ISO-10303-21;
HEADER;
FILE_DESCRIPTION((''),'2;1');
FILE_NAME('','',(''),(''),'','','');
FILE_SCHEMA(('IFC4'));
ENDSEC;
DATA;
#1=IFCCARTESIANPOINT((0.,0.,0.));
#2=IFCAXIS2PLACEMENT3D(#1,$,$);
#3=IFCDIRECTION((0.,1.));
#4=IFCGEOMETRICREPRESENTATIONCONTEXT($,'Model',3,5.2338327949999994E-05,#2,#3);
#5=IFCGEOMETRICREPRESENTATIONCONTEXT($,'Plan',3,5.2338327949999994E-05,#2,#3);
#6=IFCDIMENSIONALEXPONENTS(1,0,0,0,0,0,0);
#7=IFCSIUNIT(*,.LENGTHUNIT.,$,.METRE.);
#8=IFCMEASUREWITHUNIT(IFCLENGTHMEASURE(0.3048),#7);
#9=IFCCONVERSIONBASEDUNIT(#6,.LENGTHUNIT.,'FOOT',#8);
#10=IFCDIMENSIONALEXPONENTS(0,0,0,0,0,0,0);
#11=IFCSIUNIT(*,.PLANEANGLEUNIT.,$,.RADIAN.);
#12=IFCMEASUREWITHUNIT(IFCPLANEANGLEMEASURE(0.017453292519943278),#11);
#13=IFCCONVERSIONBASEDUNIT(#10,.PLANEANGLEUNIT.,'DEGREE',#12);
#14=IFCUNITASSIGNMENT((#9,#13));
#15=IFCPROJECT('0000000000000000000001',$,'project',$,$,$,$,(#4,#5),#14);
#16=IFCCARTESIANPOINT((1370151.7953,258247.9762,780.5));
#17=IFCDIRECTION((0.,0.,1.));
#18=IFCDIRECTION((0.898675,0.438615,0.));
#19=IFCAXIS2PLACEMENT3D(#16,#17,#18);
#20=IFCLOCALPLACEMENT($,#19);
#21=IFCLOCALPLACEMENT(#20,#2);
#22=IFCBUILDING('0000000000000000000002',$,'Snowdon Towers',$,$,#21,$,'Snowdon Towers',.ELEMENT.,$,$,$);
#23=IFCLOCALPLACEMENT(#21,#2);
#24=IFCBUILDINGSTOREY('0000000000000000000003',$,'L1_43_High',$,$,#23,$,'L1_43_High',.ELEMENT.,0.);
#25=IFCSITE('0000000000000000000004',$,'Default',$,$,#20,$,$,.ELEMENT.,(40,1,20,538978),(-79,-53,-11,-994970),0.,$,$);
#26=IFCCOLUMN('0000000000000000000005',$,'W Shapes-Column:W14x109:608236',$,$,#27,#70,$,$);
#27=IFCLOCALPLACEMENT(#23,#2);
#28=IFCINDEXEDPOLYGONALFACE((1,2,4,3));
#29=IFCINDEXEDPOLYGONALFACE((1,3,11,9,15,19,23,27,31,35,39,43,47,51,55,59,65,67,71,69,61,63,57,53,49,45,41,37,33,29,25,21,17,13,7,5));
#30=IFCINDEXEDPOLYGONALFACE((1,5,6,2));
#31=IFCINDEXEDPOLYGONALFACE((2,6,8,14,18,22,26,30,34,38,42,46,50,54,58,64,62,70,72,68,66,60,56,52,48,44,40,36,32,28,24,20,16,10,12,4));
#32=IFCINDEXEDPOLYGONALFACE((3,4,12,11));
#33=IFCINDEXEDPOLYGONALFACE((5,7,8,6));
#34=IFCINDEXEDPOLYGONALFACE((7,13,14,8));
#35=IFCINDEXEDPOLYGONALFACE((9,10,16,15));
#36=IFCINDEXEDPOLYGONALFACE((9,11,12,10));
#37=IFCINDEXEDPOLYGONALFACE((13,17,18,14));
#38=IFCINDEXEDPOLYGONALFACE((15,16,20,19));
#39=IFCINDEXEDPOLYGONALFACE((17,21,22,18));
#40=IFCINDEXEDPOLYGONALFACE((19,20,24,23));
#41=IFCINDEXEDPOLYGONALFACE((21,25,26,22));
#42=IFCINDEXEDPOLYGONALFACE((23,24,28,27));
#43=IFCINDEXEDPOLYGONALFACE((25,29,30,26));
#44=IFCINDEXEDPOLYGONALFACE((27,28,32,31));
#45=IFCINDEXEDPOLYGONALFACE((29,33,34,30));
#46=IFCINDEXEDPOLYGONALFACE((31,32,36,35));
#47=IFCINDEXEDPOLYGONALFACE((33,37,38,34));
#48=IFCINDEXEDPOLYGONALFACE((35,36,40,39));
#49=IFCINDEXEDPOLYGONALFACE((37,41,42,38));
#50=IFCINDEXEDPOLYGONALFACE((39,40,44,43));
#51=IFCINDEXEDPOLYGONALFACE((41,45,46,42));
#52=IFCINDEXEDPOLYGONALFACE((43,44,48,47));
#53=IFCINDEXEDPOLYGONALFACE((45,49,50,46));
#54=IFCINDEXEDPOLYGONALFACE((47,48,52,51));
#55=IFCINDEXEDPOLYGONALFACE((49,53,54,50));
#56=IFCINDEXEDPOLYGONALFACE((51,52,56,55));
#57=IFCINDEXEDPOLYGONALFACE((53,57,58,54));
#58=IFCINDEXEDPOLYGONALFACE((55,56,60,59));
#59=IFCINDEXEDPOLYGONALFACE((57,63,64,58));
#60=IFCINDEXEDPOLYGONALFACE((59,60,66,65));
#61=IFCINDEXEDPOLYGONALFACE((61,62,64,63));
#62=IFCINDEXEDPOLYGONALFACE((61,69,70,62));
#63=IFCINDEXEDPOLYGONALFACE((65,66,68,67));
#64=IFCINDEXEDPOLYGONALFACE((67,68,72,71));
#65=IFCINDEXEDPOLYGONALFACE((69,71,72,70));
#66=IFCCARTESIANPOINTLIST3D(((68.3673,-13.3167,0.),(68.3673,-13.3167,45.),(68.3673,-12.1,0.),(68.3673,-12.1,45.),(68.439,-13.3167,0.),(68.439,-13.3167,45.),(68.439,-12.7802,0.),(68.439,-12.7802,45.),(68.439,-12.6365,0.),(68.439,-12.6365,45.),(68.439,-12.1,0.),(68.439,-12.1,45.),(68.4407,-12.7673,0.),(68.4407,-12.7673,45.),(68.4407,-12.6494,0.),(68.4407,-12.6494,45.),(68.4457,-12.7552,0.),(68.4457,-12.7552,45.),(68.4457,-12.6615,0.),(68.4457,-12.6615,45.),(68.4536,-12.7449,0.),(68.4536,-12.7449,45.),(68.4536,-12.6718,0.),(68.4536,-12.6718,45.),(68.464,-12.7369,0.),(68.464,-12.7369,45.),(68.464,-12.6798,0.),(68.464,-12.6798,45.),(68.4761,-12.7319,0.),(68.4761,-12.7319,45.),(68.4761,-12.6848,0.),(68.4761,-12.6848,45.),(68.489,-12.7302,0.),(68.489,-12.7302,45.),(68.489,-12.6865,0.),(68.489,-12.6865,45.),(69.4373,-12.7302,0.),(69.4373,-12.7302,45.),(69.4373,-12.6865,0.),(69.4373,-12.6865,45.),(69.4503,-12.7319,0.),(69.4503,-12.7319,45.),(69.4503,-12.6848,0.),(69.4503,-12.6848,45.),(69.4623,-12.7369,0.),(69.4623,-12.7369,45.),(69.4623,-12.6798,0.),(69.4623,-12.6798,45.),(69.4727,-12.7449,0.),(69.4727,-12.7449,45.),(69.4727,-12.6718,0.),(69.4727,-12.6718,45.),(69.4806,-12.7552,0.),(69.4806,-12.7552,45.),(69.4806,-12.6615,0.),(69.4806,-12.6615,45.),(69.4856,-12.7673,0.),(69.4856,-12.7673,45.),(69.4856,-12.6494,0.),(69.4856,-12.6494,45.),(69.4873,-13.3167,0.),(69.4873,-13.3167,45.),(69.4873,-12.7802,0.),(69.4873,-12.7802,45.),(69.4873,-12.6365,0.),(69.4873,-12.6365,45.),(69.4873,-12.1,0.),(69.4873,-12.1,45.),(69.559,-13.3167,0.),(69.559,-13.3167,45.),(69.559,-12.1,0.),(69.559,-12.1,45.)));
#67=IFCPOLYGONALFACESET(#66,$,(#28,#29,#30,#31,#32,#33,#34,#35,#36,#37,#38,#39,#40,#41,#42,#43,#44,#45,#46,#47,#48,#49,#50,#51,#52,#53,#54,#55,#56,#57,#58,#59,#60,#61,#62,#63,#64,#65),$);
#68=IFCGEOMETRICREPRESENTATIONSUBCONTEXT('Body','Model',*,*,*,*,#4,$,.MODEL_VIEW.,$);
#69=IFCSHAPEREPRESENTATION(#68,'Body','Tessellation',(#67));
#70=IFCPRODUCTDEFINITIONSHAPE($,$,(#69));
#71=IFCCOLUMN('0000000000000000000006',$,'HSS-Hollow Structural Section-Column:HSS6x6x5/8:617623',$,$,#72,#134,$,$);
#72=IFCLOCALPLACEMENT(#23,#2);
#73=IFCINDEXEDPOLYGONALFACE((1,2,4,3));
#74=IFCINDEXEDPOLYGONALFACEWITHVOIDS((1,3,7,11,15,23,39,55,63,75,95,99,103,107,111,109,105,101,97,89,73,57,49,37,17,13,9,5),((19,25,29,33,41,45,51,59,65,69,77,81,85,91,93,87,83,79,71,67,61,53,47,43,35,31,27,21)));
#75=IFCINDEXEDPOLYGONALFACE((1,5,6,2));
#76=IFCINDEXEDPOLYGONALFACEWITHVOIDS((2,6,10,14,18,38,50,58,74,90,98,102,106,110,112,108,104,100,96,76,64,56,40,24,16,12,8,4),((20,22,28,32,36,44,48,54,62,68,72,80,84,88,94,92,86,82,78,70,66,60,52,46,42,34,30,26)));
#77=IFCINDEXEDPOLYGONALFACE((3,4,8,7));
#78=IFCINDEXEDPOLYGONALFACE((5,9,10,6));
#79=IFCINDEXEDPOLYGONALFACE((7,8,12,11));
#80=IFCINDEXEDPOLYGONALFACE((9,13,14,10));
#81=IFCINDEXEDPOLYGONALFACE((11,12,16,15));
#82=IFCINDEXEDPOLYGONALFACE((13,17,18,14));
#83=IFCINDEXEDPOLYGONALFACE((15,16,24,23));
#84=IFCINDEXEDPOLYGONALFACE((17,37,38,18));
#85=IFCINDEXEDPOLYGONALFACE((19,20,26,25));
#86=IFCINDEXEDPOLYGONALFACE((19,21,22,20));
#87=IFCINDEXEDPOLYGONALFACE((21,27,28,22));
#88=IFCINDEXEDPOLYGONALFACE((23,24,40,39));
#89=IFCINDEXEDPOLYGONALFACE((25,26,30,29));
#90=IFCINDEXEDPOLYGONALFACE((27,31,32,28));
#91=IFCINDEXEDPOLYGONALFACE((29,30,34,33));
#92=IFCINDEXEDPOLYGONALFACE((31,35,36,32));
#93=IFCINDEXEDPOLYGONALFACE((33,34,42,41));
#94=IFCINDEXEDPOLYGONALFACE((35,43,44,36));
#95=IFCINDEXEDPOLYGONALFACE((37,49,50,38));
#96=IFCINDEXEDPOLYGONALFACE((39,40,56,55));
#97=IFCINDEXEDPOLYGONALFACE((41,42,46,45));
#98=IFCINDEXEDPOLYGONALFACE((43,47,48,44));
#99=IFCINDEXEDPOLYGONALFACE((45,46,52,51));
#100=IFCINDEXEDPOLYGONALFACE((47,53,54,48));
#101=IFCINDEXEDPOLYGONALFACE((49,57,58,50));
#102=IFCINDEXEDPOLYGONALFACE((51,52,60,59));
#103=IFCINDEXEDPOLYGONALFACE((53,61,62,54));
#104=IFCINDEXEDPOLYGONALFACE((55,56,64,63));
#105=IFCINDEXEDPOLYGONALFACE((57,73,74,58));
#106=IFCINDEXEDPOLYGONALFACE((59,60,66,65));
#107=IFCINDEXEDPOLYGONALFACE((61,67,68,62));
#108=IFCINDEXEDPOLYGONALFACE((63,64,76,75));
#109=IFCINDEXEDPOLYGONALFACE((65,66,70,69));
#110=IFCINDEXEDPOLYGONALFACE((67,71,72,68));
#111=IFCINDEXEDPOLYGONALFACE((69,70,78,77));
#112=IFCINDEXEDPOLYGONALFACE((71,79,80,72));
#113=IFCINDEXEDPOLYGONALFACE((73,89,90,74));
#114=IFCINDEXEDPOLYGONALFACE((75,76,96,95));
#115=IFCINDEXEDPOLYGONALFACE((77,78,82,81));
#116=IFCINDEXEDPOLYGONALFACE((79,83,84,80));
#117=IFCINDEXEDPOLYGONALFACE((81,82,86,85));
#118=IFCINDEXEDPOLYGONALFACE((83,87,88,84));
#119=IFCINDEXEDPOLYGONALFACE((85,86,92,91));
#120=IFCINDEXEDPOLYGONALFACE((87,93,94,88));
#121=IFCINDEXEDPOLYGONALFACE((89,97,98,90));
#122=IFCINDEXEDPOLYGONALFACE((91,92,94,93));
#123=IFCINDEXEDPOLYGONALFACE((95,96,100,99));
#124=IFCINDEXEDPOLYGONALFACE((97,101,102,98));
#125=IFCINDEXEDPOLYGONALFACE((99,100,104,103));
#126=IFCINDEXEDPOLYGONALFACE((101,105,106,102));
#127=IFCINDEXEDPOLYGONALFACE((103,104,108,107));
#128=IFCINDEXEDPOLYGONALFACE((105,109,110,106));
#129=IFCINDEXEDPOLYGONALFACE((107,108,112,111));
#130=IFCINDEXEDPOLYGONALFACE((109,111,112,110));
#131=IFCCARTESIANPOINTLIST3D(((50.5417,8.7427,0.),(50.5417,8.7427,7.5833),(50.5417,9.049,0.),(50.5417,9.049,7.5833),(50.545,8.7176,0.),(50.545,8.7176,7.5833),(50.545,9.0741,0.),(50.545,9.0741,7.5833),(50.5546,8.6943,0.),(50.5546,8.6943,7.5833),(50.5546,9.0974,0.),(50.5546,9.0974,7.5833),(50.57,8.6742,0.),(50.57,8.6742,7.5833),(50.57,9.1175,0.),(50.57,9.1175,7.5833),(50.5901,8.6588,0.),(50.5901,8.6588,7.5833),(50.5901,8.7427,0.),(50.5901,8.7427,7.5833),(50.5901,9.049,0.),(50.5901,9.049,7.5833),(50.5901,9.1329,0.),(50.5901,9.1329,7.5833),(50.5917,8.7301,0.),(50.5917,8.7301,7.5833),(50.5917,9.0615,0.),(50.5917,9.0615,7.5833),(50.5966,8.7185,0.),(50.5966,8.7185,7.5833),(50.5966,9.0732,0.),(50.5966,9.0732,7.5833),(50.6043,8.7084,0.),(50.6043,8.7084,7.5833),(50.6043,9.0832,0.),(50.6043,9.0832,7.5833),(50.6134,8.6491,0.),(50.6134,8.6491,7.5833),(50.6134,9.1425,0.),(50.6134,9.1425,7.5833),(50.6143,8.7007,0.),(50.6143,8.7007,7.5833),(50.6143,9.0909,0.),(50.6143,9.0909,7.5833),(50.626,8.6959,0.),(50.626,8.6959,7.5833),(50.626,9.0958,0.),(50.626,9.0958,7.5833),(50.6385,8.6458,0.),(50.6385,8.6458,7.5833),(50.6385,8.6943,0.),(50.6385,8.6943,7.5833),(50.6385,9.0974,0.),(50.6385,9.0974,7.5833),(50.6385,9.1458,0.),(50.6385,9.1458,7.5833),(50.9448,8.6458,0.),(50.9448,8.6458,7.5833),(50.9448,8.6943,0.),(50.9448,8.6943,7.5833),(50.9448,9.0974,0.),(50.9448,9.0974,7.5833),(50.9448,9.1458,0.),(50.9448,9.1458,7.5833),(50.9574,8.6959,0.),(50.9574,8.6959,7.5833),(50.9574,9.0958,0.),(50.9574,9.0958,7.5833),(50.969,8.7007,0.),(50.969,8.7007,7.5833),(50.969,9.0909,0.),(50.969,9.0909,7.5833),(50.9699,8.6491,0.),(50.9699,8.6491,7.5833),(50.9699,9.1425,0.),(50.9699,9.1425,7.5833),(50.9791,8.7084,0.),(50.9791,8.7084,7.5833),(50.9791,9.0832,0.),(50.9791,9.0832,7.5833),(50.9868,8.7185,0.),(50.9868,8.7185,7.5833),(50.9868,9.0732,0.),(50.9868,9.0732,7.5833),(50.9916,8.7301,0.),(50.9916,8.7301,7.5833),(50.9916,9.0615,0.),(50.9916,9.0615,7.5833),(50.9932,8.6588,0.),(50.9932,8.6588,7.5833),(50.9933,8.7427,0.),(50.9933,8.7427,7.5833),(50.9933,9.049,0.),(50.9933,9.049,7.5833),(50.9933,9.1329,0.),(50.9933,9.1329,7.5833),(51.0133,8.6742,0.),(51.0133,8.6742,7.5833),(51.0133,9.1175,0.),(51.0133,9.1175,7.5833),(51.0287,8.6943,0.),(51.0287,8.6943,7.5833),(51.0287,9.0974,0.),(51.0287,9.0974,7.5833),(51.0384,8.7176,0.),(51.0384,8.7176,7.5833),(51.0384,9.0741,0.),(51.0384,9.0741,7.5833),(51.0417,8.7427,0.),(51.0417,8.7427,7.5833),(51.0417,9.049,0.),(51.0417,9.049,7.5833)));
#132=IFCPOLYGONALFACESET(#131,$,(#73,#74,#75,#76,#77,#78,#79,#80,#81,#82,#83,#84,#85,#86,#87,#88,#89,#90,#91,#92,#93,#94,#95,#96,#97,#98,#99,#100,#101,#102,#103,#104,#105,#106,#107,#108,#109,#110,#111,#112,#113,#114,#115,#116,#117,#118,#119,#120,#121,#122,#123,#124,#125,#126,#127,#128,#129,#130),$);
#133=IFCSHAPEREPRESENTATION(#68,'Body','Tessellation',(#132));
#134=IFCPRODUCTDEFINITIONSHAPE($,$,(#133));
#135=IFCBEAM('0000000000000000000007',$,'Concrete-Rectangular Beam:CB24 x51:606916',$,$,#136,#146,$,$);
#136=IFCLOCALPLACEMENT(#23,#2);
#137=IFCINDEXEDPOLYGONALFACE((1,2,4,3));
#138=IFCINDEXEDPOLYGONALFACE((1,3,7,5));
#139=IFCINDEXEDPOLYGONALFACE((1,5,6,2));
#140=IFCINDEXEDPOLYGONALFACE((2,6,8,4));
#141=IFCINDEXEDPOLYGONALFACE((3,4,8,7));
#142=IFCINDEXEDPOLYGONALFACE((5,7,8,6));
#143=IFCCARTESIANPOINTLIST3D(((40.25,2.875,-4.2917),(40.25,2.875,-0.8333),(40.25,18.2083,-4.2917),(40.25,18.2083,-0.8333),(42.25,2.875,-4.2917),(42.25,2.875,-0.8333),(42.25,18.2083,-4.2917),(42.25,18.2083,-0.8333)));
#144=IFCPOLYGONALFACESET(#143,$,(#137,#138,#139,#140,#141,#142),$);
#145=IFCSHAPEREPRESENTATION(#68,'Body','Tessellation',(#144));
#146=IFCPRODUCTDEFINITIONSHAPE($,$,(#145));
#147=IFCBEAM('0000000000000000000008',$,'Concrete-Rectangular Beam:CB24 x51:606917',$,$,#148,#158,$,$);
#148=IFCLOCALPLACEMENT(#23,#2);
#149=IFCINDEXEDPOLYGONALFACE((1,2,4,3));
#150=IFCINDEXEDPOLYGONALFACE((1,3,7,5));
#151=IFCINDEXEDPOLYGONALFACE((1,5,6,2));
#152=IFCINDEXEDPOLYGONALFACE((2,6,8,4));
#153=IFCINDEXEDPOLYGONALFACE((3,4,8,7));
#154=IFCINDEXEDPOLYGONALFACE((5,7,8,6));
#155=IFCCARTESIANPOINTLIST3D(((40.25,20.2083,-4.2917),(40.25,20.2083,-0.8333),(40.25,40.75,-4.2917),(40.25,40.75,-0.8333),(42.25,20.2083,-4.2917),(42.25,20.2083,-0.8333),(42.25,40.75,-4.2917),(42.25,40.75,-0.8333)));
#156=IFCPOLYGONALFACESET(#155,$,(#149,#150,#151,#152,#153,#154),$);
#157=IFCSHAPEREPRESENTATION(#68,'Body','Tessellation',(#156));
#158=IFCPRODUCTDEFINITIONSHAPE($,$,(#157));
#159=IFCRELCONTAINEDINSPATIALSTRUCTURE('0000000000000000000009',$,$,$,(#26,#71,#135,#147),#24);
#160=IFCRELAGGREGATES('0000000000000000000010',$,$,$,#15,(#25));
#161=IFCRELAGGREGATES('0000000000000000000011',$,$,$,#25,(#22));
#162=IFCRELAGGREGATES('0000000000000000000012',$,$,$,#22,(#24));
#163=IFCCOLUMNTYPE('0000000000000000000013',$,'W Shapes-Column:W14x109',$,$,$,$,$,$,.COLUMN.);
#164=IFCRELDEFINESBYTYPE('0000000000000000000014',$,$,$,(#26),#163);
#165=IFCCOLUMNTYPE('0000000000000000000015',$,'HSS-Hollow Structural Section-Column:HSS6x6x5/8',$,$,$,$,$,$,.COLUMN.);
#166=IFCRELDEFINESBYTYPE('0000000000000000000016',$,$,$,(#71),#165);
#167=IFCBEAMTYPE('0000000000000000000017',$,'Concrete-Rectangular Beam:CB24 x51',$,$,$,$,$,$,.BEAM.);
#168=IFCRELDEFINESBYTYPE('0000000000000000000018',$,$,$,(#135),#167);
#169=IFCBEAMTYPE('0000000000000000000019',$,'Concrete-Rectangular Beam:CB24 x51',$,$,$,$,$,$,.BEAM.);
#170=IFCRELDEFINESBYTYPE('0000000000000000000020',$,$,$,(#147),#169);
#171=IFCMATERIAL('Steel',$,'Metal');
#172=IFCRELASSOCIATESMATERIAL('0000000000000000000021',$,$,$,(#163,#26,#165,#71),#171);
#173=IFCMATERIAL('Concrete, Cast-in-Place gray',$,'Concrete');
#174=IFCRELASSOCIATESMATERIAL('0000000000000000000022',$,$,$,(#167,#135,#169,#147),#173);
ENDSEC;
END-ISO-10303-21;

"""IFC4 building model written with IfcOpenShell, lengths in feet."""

from ifc_helpers import new_model, entity, si_unit, converted_unit, direction, frame, origin, place, context, subcontext, project, spatial, line, arc, indexed_curve, outline, extrude, source, transform, mapped, material, type_object, type_shapes, element, save


model = new_model("IFC4")

# Units and contexts
model_context = context("Model", 3, precision=5.2338327949999994e-05, world=origin(), true_north=direction((0.0, 1.0)))
plan_context = context("Plan", 3, precision=5.2338327949999994e-05, world=origin(), true_north=direction((0.0, 1.0)))
body_context = subcontext(model_context, "Body", "Model", "MODEL_VIEW")
ifc_project = project(units=[converted_unit("LENGTHUNIT", "FOOT", entity("IfcLengthMeasure", 0.3048), si_unit("LENGTHUNIT", "METRE"), dimensions=[1, 0, 0, 0, 0, 0, 0]), converted_unit("PLANEANGLEUNIT", "DEGREE", entity("IfcPlaneAngleMeasure", 0.017453292519943278), si_unit("PLANEANGLEUNIT", "RADIAN"), dimensions=[0, 0, 0, 0, 0, 0, 0])], contexts=[model_context, plan_context])

# Site, building, storey
site_placement = place(None, frame((1370151.7953, 258247.9762, 780.5), z_axis=(0.0, 0.0, 1.0), x_axis=(0.898675, 0.438615, 0.0)))
site = spatial("IfcSite", under=ifc_project, at=site_placement, Name="Default", CompositionType="ELEMENT", RefLatitude=(40, 1, 20, 538978), RefLongitude=(-79, -53, -11, -994970), RefElevation=0.0)
building_placement = place(site_placement, origin())
building = spatial("IfcBuilding", under=site, at=building_placement, Name="Snowdon Towers", LongName="Snowdon Towers", CompositionType="ELEMENT")
storey_placement = place(building_placement, origin())
storey = spatial("IfcBuildingStorey", under=building, at=storey_placement, Name="L1_43_High", LongName="L1_43_High", CompositionType="ELEMENT", Elevation=0.0)

# Columns
ifc_material_1 = material(Name="Steel", Category="Metal")
column_type_1 = type_object("IfcColumnType", Name="W Shapes-Column:W14x109", PredefinedType="COLUMN", material=ifc_material_1)
shared_shape_1 = source(origin(), body_context, "Body", "SweptSolid", [
    extrude(outline(indexed_curve([(-0.6083, -0.5958), (0.6083, -0.5958), (0.6083, -0.5242), (0.0719, -0.5242), (0.0365, -0.5095), (0.0219, -0.4742), (0.0219, 0.4742), (0.0365, 0.5095), (0.0719, 0.5242), (0.6083, 0.5242), (0.6083, 0.5958), (-0.6083, 0.5958), (-0.6083, 0.5242), (-0.0719, 0.5242), (-0.0365, 0.5095), (-0.0219, 0.4742), (-0.0219, -0.4742), (-0.0365, -0.5095), (-0.0719, -0.5242), (-0.6083, -0.5242)], segments=[line(1, 2, 3, 4), arc(4, 5, 6), line(6, 7), arc(7, 8, 9), line(9, 10, 11, 12, 13, 14), arc(14, 15, 16), line(16, 17), arc(17, 18, 19), line(19, 20, 1)], self_intersect=False)), frame((0.0, 0.0, 0.0), z_axis=(0.0, 0.0, 1.0), x_axis=(-1.0, 0.0, 0.0)), (0.0, 0.0, 1.0), 45.0),
])
type_shapes(column_type_1, [shared_shape_1])
for number, where, z_axis, x_axis, name in (
    (1, (68.9632, -12.7083, 0.0), (0.0, 0.0, 1.0), (0.0, 1.0, 0.0), "W Shapes-Column:W14x109:608236"),
):
    element("IfcColumn", number, at=place(storey_placement, frame(where, z_axis=z_axis, x_axis=x_axis)), inside=storey, type_object=column_type_1, material=ifc_material_1, Name=name, context=body_context, shape_type="MappedRepresentation", body=[
        mapped(shared_shape_1, transform((0.0, 0.0, 0.0), scale=1.0)),
    ])
column_type_2 = type_object("IfcColumnType", Name="HSS-Hollow Structural Section-Column:HSS6x6x5/8", PredefinedType="COLUMN", material=ifc_material_1)
shared_shape_2 = source(origin(), body_context, "Body", "SweptSolid", [
    extrude(outline(indexed_curve([(-0.1532, -0.25), (0.1532, -0.25), (0.2216, -0.2216), (0.25, -0.1532), (0.25, 0.1532), (0.2216, 0.2216), (0.1532, 0.25), (-0.1532, 0.25), (-0.2216, 0.2216), (-0.25, 0.1532), (-0.25, -0.1532), (-0.2216, -0.2216)], segments=[line(1, 2), arc(2, 3, 4), line(4, 5), arc(5, 6, 7), line(7, 8), arc(8, 9, 10), line(10, 11), arc(11, 12, 1)], self_intersect=False), holes=[indexed_curve([(-0.1532, -0.2016), (-0.1874, -0.1874), (-0.2016, -0.1532), (-0.2016, 0.1532), (-0.1874, 0.1874), (-0.1532, 0.2016), (0.1532, 0.2016), (0.1874, 0.1874), (0.2016, 0.1532), (0.2016, -0.1532), (0.1874, -0.1874), (0.1532, -0.2016)], segments=[arc(1, 2, 3), line(3, 4), arc(4, 5, 6), line(6, 7), arc(7, 8, 9), line(9, 10), arc(10, 11, 12), line(12, 1)], self_intersect=False)]), frame((0.0, 0.0, 0.0), z_axis=(0.0, 0.0, 1.0), x_axis=(-1.0, 0.0, 0.0)), (0.0, 0.0, 1.0), 7.5833),
])
type_shapes(column_type_2, [shared_shape_2])
column_1_placement = place(storey_placement, frame((50.7917, 8.8958, 0.0), z_axis=(0.0, 0.0, 1.0), x_axis=(0.0, 1.0, 0.0)))
element("IfcColumn", 2, at=column_1_placement, inside=storey, type_object=column_type_2, material=ifc_material_1, Name="HSS-Hollow Structural Section-Column:HSS6x6x5/8:617623", context=body_context, shape_type="MappedRepresentation", body=[
    mapped(shared_shape_2, transform((0.0, 0.0, 0.0), scale=1.0)),
])

# Beams
ifc_material_2 = material(Name="Concrete, Cast-in-Place gray", Category="Concrete")
beam_type_1 = type_object("IfcBeamType", Name="Concrete-Rectangular Beam:CB24 x51", PredefinedType="BEAM", material=ifc_material_2)
shared_shape_3 = source(origin(), body_context, "Body", "SweptSolid", [
    extrude(outline(indexed_curve([(-1.0, -1.7292), (1.0, -1.7292), (1.0, 1.7292), (-1.0, 1.7292), (-1.0, -1.7292)], self_intersect=False)), frame((41.25, 2.875, -2.5625), z_axis=(0.0, 1.0, 0.0), x_axis=(-1.0, 0.0, 0.0)), (0.0, 0.0, 1.0), 15.3333),
])
type_shapes(beam_type_1, [shared_shape_3])
beam_1_placement = place(storey_placement, origin())
element("IfcBeam", 3, at=beam_1_placement, inside=storey, type_object=beam_type_1, material=ifc_material_2, Name="Concrete-Rectangular Beam:CB24 x51:606916", context=body_context, shape_type="MappedRepresentation", body=[
    mapped(shared_shape_3, transform((0.0, 0.0, 0.0), scale=1.0)),
])
beam_type_2 = type_object("IfcBeamType", Name="Concrete-Rectangular Beam:CB24 x51", PredefinedType="BEAM", material=ifc_material_2)
shared_shape_4 = source(origin(), body_context, "Body", "SweptSolid", [
    extrude(outline(indexed_curve([(-1.0, -1.7292), (1.0, -1.7292), (1.0, 1.7292), (-1.0, 1.7292), (-1.0, -1.7292)], self_intersect=False)), frame((41.25, 20.2083, -2.5625), z_axis=(0.0, 1.0, 0.0), x_axis=(-1.0, 0.0, 0.0)), (0.0, 0.0, 1.0), 20.5417),
])
type_shapes(beam_type_2, [shared_shape_4])
beam_2_placement = place(storey_placement, origin())
element("IfcBeam", 4, at=beam_2_placement, inside=storey, type_object=beam_type_2, material=ifc_material_2, Name="Concrete-Rectangular Beam:CB24 x51:606917", context=body_context, shape_type="MappedRepresentation", body=[
    mapped(shared_shape_4, transform((0.0, 0.0, 0.0), scale=1.0)),
])

save(model, "model.ifc")
